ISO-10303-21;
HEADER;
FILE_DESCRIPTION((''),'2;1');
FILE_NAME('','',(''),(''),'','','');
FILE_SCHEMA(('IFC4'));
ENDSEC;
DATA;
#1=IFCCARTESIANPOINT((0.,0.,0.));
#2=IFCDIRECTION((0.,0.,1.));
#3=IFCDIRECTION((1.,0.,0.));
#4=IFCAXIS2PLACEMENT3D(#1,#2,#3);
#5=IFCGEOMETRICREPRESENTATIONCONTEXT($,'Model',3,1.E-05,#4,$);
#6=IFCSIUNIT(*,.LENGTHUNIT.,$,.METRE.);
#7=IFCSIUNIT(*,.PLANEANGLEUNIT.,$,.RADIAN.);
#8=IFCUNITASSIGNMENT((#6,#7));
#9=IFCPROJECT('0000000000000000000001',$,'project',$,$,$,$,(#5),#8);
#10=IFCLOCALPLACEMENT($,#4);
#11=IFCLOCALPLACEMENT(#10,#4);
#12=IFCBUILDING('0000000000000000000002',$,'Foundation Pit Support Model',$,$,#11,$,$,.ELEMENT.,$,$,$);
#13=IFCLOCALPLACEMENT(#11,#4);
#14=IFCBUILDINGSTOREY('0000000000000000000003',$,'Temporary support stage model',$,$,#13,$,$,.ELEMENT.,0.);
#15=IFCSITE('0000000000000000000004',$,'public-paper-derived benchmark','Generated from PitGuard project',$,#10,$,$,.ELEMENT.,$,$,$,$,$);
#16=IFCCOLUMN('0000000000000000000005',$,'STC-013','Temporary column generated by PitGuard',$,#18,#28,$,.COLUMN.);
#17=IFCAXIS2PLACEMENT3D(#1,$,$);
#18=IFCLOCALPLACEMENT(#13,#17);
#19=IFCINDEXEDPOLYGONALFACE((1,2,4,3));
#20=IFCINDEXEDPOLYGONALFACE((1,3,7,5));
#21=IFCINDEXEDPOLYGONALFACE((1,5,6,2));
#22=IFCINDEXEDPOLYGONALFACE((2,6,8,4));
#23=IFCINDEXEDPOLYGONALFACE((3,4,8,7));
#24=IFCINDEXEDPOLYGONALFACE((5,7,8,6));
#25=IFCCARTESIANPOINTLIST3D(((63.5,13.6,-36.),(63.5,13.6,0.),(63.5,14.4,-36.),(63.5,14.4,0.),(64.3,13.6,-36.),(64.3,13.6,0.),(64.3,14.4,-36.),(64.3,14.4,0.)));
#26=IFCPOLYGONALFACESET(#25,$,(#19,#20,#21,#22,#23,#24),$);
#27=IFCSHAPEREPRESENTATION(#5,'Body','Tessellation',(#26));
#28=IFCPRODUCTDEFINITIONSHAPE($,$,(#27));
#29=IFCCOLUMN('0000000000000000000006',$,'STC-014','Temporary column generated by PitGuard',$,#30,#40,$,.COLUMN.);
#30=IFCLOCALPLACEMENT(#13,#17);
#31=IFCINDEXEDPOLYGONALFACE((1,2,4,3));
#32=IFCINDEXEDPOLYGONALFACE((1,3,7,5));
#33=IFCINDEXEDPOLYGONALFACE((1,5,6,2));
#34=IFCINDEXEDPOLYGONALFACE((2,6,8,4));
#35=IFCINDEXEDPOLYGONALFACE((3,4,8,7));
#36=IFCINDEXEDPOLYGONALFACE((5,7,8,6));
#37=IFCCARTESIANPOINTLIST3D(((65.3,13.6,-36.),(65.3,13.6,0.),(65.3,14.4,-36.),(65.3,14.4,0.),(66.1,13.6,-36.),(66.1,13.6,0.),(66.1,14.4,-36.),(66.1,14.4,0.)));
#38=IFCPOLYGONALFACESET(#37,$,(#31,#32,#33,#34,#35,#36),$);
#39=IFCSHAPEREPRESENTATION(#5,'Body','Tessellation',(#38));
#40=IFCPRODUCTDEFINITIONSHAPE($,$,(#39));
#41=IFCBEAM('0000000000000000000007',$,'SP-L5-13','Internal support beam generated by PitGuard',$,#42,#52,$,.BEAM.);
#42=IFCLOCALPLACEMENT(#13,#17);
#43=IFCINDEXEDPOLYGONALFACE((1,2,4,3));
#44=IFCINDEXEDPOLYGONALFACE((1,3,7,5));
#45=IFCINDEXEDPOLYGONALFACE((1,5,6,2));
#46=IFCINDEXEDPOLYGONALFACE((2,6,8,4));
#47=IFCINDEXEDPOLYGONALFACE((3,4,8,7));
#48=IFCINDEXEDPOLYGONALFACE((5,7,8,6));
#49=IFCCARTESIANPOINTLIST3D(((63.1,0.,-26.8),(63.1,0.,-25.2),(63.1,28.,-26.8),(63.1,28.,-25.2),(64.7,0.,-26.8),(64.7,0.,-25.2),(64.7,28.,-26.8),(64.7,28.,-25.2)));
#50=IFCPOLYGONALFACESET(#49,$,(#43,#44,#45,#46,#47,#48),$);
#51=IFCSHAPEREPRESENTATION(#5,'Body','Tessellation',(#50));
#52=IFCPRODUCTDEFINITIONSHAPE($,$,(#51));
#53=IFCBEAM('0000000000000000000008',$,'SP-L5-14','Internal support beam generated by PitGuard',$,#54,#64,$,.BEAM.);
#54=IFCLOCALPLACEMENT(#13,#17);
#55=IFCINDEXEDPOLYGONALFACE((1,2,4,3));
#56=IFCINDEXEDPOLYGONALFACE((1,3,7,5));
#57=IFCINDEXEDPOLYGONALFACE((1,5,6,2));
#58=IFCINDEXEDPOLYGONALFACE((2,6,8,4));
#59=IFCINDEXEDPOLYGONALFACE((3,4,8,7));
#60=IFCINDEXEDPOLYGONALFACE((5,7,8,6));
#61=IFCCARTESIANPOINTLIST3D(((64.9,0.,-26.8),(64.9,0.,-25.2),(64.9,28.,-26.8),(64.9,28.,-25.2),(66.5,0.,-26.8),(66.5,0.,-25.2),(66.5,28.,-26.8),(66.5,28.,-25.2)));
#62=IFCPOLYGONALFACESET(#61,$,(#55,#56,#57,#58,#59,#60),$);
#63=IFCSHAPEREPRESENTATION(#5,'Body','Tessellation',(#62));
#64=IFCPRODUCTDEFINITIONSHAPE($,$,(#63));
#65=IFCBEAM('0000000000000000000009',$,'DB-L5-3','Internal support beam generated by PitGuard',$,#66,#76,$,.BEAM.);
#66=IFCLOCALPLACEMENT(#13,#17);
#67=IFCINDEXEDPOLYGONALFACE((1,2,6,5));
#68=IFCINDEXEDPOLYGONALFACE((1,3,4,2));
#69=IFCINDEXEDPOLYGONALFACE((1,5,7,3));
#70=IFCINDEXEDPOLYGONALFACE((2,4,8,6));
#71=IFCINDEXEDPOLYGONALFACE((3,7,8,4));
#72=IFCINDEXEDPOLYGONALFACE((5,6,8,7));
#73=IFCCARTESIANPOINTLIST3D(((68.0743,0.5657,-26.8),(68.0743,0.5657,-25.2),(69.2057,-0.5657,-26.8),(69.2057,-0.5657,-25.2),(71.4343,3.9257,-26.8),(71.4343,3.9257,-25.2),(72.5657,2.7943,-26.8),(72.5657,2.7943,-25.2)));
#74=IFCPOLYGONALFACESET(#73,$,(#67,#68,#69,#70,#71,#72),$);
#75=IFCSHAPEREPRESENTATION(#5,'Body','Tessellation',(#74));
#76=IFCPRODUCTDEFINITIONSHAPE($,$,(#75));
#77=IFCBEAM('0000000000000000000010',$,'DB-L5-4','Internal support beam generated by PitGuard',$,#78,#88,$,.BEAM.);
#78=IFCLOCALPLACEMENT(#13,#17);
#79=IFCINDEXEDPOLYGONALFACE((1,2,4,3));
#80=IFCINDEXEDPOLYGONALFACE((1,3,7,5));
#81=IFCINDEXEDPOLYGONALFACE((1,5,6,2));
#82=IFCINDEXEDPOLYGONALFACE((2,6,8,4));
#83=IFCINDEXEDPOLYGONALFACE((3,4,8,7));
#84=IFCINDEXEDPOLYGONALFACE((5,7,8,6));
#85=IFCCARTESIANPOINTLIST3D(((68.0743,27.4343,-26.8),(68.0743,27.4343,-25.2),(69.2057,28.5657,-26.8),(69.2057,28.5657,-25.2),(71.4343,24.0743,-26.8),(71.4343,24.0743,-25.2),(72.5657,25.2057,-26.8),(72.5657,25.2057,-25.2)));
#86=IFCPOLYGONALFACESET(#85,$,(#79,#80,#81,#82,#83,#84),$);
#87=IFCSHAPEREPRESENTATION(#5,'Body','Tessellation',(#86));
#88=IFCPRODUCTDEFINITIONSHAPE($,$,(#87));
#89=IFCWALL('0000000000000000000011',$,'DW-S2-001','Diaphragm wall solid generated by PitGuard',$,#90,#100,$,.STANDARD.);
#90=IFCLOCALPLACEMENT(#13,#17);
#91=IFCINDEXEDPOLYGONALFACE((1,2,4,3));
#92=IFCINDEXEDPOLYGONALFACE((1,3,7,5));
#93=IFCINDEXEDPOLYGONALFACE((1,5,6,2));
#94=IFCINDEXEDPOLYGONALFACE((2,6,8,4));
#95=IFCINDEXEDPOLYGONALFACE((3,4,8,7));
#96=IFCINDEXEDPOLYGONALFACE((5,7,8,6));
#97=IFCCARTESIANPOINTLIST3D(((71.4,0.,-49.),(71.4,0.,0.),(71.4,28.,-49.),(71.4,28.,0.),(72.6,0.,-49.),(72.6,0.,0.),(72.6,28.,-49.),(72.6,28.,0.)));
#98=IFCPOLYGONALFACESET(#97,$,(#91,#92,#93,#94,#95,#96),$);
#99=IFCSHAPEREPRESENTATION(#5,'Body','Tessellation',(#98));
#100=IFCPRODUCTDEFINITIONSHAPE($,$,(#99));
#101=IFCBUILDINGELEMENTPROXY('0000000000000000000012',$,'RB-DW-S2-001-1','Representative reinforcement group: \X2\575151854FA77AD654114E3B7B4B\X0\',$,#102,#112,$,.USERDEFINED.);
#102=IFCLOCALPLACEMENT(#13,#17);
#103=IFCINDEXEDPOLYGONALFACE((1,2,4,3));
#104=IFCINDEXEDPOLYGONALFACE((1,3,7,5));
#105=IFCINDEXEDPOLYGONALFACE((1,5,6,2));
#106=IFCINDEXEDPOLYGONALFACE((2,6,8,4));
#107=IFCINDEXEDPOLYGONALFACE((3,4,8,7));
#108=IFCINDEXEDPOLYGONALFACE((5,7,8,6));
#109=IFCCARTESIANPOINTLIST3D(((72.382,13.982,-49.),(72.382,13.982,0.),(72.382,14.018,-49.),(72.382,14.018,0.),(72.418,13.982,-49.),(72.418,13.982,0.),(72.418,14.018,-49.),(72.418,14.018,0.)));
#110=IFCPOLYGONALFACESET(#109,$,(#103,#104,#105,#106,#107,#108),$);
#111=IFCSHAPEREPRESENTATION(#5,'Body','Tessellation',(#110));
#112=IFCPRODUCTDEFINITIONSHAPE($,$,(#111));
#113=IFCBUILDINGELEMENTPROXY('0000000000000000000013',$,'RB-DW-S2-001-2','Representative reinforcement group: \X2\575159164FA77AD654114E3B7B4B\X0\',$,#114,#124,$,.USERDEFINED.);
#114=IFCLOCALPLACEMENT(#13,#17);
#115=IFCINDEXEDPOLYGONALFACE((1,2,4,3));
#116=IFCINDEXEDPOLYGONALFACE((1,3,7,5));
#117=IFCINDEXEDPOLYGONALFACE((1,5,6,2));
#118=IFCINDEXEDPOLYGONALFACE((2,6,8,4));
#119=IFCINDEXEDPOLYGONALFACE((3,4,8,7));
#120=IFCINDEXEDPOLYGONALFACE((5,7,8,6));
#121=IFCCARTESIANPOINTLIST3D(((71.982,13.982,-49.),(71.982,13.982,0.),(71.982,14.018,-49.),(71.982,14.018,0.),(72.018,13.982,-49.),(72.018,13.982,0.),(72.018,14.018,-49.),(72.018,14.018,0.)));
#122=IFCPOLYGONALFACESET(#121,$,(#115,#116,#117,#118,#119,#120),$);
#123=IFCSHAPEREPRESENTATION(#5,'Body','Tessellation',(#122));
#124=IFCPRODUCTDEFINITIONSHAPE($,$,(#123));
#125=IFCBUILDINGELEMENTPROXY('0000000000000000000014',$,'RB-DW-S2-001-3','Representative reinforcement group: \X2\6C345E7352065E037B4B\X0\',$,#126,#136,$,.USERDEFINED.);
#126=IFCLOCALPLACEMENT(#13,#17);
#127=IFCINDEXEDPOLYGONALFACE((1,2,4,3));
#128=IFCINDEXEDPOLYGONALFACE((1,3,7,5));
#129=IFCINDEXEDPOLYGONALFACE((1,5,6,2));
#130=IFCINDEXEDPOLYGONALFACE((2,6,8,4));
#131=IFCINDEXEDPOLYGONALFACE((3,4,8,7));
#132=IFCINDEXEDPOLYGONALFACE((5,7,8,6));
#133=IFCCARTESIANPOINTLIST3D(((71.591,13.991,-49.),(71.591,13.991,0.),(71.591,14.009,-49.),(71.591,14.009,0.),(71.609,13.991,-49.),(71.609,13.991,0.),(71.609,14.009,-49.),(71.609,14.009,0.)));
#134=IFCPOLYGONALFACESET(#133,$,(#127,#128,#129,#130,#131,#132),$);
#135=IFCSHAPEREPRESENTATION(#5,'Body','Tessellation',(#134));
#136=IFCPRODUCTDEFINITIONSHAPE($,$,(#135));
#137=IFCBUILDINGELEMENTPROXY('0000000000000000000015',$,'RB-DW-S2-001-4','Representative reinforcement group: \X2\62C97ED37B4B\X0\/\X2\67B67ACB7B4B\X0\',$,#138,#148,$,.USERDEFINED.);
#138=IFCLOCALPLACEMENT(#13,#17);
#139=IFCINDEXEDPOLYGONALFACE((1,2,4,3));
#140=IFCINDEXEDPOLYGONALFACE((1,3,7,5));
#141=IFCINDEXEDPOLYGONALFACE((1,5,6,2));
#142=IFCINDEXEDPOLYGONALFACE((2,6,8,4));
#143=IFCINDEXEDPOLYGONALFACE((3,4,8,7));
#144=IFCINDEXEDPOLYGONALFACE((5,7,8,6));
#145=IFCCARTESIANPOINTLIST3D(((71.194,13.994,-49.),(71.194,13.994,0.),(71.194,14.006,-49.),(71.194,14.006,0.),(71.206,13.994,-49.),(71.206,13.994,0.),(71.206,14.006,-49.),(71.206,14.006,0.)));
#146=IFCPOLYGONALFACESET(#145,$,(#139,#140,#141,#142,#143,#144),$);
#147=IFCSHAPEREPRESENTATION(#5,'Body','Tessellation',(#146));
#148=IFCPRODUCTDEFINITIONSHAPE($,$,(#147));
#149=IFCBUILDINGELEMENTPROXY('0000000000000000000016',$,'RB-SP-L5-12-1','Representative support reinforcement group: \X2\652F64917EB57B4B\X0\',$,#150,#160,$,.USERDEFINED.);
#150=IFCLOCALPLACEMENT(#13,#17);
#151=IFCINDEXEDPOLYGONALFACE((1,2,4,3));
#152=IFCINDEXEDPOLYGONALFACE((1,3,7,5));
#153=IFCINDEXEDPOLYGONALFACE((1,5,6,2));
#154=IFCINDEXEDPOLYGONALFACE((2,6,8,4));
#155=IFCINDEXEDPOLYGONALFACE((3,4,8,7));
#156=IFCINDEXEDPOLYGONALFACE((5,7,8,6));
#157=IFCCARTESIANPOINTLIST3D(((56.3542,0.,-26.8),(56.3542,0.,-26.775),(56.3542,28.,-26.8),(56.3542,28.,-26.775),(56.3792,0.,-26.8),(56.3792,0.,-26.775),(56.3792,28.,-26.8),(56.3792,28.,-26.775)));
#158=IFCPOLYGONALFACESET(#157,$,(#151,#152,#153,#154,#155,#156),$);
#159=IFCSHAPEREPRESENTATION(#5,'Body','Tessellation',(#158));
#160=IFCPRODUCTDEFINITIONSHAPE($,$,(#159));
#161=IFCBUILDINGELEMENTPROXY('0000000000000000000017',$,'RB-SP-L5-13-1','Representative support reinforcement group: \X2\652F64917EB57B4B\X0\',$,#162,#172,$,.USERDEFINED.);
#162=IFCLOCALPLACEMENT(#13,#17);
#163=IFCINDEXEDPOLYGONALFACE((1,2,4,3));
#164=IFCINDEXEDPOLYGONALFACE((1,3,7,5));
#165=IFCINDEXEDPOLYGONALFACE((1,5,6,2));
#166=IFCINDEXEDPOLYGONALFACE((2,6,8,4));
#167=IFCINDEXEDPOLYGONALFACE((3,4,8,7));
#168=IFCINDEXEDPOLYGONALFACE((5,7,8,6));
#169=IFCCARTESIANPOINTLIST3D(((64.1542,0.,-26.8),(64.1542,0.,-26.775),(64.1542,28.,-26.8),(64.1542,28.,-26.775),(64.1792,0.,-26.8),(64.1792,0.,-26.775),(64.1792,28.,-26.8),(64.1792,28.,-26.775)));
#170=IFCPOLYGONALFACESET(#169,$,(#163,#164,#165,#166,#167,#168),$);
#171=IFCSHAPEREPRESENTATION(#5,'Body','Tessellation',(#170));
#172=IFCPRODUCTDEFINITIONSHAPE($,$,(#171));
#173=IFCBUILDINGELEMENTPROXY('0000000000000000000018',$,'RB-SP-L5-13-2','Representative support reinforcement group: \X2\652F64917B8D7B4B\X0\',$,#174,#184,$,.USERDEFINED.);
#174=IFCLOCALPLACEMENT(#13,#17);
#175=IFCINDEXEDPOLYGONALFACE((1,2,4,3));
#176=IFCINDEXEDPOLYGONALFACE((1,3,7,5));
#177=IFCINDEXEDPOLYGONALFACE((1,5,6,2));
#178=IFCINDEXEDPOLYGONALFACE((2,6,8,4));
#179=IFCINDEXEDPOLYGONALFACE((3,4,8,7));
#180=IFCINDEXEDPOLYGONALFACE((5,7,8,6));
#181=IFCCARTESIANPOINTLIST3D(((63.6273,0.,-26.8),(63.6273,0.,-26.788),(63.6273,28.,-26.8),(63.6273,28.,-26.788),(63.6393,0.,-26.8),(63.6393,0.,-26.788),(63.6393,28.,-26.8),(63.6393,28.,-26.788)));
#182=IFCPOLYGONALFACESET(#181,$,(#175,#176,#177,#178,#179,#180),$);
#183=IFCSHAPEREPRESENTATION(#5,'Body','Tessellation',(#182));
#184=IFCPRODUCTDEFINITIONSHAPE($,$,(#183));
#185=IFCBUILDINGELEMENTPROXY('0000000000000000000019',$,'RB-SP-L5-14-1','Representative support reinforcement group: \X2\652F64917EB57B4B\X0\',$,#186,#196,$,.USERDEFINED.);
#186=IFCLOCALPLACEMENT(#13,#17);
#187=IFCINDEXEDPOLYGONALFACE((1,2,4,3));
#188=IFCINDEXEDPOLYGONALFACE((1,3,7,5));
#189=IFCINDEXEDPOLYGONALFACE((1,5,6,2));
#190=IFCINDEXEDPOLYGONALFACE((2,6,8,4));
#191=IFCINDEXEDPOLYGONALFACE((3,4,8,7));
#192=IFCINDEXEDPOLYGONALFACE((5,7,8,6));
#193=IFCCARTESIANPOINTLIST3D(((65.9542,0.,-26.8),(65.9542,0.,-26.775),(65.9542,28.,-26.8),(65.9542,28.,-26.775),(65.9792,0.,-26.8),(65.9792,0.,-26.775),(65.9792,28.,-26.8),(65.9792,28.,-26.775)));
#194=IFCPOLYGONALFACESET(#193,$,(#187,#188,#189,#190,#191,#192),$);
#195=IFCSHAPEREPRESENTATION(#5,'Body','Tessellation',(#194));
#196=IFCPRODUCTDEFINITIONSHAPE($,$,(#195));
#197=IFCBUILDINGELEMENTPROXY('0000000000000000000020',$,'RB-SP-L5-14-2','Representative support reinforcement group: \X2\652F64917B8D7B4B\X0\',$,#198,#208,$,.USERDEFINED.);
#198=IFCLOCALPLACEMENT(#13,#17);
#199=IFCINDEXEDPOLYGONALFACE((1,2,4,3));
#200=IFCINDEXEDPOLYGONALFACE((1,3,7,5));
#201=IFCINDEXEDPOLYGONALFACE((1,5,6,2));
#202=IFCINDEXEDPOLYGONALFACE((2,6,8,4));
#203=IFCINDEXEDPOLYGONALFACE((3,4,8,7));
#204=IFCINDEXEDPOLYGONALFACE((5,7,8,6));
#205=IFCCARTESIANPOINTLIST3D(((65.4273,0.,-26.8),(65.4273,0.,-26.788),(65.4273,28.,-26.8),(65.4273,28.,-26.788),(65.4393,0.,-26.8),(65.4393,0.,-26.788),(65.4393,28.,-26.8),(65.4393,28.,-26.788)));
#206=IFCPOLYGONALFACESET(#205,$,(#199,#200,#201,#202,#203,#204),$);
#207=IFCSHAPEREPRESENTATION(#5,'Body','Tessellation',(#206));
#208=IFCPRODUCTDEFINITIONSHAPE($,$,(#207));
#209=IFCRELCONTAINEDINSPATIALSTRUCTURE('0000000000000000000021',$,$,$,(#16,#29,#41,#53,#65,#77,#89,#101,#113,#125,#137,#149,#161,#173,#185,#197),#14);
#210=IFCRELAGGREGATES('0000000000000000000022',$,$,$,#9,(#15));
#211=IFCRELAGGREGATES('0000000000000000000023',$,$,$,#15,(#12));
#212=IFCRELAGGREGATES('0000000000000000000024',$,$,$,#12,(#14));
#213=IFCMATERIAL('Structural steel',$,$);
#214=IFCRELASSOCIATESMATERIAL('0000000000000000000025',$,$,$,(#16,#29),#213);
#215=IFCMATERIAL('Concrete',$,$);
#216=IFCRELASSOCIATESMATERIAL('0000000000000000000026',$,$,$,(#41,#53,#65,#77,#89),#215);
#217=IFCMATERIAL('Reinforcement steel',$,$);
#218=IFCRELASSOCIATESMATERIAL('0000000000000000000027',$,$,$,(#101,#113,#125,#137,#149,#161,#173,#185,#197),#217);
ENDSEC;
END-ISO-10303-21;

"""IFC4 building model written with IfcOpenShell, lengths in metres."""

from ifc_helpers import new_model, si_unit, frame, origin_with_axes, origin_2d, place, context, project, spatial, rectangle, extrude, material, element, save


model = new_model("IFC4")

# Units and contexts
model_context = context("Model", 3, precision=1e-05, world=origin_with_axes())
ifc_project = project(units=[si_unit("LENGTHUNIT", "METRE"), si_unit("PLANEANGLEUNIT", "RADIAN")], contexts=[model_context])

# Site, building, storey
site_placement = place(None, origin_with_axes())
site = spatial("IfcSite", under=ifc_project, at=site_placement, Name="public-paper-derived benchmark", Description="Generated from PitGuard project", CompositionType="ELEMENT")
building_placement = place(site_placement, origin_with_axes())
building = spatial("IfcBuilding", under=site, at=building_placement, Name="Foundation Pit Support Model", CompositionType="ELEMENT")
storey_placement = place(building_placement, origin_with_axes())
storey = spatial("IfcBuildingStorey", under=building, at=storey_placement, Name="Temporary support stage model", CompositionType="ELEMENT", Elevation=0.0)

# Columns
ifc_material_1 = material(Name="Structural steel")
for number, where, z_axis, x_axis, name in (
    (1, (63.9, 14.0, -36.0), (0.0, 0.0, 1.0), (1.0, 0.0, 0.0), "STC-013"),
    (2, (65.7, 14.0, -36.0), (0.0, 0.0, 1.0), (1.0, 0.0, 0.0), "STC-014"),
):
    element("IfcColumn", number, at=place(storey_placement, frame(where, z_axis=z_axis, x_axis=x_axis)), inside=storey, material=ifc_material_1, Name=name, Description="Temporary column generated by PitGuard", PredefinedType="COLUMN", context=model_context, shape_type="SweptSolid", body=[
        extrude(rectangle(XDim=0.8, YDim=0.8, at=origin_2d()), origin_with_axes(), (0.0, 0.0, 1.0), 36.0),
    ])

# Beams
ifc_material_2 = material(Name="Concrete")
for number, where, z_axis, x_axis, name in (
    (3, (63.9, 14.0, -26.8), (0.0, 0.0, 1.0), (0.0, 1.0, 0.0), "SP-L5-13"),
    (4, (65.7, 14.0, -26.8), (0.0, 0.0, 1.0), (0.0, 1.0, 0.0), "SP-L5-14"),
):
    element("IfcBeam", number, at=place(storey_placement, frame(where, z_axis=z_axis, x_axis=x_axis)), inside=storey, material=ifc_material_2, Name=name, Description="Internal support beam generated by PitGuard", PredefinedType="BEAM", context=model_context, shape_type="SweptSolid", body=[
        extrude(rectangle(XDim=28.0, YDim=1.6, at=origin_2d()), origin_with_axes(), (0.0, 0.0, 1.0), 1.6),
    ])
for number, where, z_axis, x_axis, name in (
    (5, (70.32, 1.68, -26.8), (0.0, 0.0, 1.0), (0.707107, 0.707107, 0.0), "DB-L5-3"),
    (6, (70.32, 26.32, -26.8), (0.0, 0.0, 1.0), (-0.707107, 0.707107, 0.0), "DB-L5-4"),
):
    element("IfcBeam", number, at=place(storey_placement, frame(where, z_axis=z_axis, x_axis=x_axis)), inside=storey, material=ifc_material_2, Name=name, Description="Internal support beam generated by PitGuard", PredefinedType="BEAM", context=model_context, shape_type="SweptSolid", body=[
        extrude(rectangle(XDim=4.7518, YDim=1.6, at=origin_2d()), origin_with_axes(), (0.0, 0.0, 1.0), 1.6),
    ])

# Wall
wall_placement = place(storey_placement, frame((72.0, 14.0, -49.0), z_axis=(0.0, 0.0, 1.0), x_axis=(0.0, 1.0, 0.0)))
element("IfcWall", 7, at=wall_placement, inside=storey, material=ifc_material_2, Name="DW-S2-001", Description="Diaphragm wall solid generated by PitGuard", PredefinedType="STANDARD", context=model_context, shape_type="SweptSolid", body=[
    extrude(rectangle(XDim=28.0, YDim=1.2, at=origin_2d()), origin_with_axes(), (0.0, 0.0, 1.0), 49.0),
])

# Building element proxies
ifc_material_3 = material(Name="Reinforcement steel")
for number, where, z_axis, x_axis, name, description in (
    (8, (72.4, 14.0, -49.0), (0.0, 0.0, 1.0), (1.0, 0.0, 0.0), "RB-DW-S2-001-1", "Representative reinforcement group: 坑内侧竖向主筋"),
    (9, (72.0, 14.0, -49.0), (0.0, 0.0, 1.0), (1.0, 0.0, 0.0), "RB-DW-S2-001-2", "Representative reinforcement group: 坑外侧竖向主筋"),
):
    element("IfcBuildingElementProxy", number, at=place(storey_placement, frame(where, z_axis=z_axis, x_axis=x_axis)), inside=storey, material=ifc_material_3, Name=name, Description=description, PredefinedType="USERDEFINED", context=model_context, shape_type="SweptSolid", body=[
        extrude(rectangle(XDim=0.036, YDim=0.036, at=origin_2d()), origin_with_axes(), (0.0, 0.0, 1.0), 49.0),
    ])
proxy_1_placement = place(storey_placement, frame((71.6, 14.0, -49.0), z_axis=(0.0, 0.0, 1.0), x_axis=(1.0, 0.0, 0.0)))
element("IfcBuildingElementProxy", 10, at=proxy_1_placement, inside=storey, material=ifc_material_3, Name="RB-DW-S2-001-3", Description="Representative reinforcement group: 水平分布筋", PredefinedType="USERDEFINED", context=model_context, shape_type="SweptSolid", body=[
    extrude(rectangle(XDim=0.018, YDim=0.018, at=origin_2d()), origin_with_axes(), (0.0, 0.0, 1.0), 49.0),
])
proxy_2_placement = place(storey_placement, frame((71.2, 14.0, -49.0), z_axis=(0.0, 0.0, 1.0), x_axis=(1.0, 0.0, 0.0)))
element("IfcBuildingElementProxy", 11, at=proxy_2_placement, inside=storey, material=ifc_material_3, Name="RB-DW-S2-001-4", Description="Representative reinforcement group: 拉结筋/架立筋", PredefinedType="USERDEFINED", context=model_context, shape_type="SweptSolid", body=[
    extrude(rectangle(XDim=0.012, YDim=0.012, at=origin_2d()), origin_with_axes(), (0.0, 0.0, 1.0), 49.0),
])
for number, where, z_axis, x_axis, name in (
    (12, (56.3667, 14.0, -26.8), (0.0, 0.0, 1.0), (0.0, 1.0, 0.0), "RB-SP-L5-12-1"),
    (13, (64.1667, 14.0, -26.8), (0.0, 0.0, 1.0), (0.0, 1.0, 0.0), "RB-SP-L5-13-1"),
):
    element("IfcBuildingElementProxy", number, at=place(storey_placement, frame(where, z_axis=z_axis, x_axis=x_axis)), inside=storey, material=ifc_material_3, Name=name, Description="Representative support reinforcement group: 支撑纵筋", PredefinedType="USERDEFINED", context=model_context, shape_type="SweptSolid", body=[
        extrude(rectangle(XDim=28.0, YDim=0.025, at=origin_2d()), origin_with_axes(), (0.0, 0.0, 1.0), 0.025),
    ])
proxy_3_placement = place(storey_placement, frame((63.6333, 14.0, -26.8), z_axis=(0.0, 0.0, 1.0), x_axis=(0.0, 1.0, 0.0)))
element("IfcBuildingElementProxy", 14, at=proxy_3_placement, inside=storey, material=ifc_material_3, Name="RB-SP-L5-13-2", Description="Representative support reinforcement group: 支撑箍筋", PredefinedType="USERDEFINED", context=model_context, shape_type="SweptSolid", body=[
    extrude(rectangle(XDim=28.0, YDim=0.012, at=origin_2d()), origin_with_axes(), (0.0, 0.0, 1.0), 0.012),
])
proxy_4_placement = place(storey_placement, frame((65.9667, 14.0, -26.8), z_axis=(0.0, 0.0, 1.0), x_axis=(0.0, 1.0, 0.0)))
element("IfcBuildingElementProxy", 15, at=proxy_4_placement, inside=storey, material=ifc_material_3, Name="RB-SP-L5-14-1", Description="Representative support reinforcement group: 支撑纵筋", PredefinedType="USERDEFINED", context=model_context, shape_type="SweptSolid", body=[
    extrude(rectangle(XDim=28.0, YDim=0.025, at=origin_2d()), origin_with_axes(), (0.0, 0.0, 1.0), 0.025),
])
proxy_5_placement = place(storey_placement, frame((65.4333, 14.0, -26.8), z_axis=(0.0, 0.0, 1.0), x_axis=(0.0, 1.0, 0.0)))
element("IfcBuildingElementProxy", 16, at=proxy_5_placement, inside=storey, material=ifc_material_3, Name="RB-SP-L5-14-2", Description="Representative support reinforcement group: 支撑箍筋", PredefinedType="USERDEFINED", context=model_context, shape_type="SweptSolid", body=[
    extrude(rectangle(XDim=28.0, YDim=0.012, at=origin_2d()), origin_with_axes(), (0.0, 0.0, 1.0), 0.012),
])

save(model, "model.ifc")
